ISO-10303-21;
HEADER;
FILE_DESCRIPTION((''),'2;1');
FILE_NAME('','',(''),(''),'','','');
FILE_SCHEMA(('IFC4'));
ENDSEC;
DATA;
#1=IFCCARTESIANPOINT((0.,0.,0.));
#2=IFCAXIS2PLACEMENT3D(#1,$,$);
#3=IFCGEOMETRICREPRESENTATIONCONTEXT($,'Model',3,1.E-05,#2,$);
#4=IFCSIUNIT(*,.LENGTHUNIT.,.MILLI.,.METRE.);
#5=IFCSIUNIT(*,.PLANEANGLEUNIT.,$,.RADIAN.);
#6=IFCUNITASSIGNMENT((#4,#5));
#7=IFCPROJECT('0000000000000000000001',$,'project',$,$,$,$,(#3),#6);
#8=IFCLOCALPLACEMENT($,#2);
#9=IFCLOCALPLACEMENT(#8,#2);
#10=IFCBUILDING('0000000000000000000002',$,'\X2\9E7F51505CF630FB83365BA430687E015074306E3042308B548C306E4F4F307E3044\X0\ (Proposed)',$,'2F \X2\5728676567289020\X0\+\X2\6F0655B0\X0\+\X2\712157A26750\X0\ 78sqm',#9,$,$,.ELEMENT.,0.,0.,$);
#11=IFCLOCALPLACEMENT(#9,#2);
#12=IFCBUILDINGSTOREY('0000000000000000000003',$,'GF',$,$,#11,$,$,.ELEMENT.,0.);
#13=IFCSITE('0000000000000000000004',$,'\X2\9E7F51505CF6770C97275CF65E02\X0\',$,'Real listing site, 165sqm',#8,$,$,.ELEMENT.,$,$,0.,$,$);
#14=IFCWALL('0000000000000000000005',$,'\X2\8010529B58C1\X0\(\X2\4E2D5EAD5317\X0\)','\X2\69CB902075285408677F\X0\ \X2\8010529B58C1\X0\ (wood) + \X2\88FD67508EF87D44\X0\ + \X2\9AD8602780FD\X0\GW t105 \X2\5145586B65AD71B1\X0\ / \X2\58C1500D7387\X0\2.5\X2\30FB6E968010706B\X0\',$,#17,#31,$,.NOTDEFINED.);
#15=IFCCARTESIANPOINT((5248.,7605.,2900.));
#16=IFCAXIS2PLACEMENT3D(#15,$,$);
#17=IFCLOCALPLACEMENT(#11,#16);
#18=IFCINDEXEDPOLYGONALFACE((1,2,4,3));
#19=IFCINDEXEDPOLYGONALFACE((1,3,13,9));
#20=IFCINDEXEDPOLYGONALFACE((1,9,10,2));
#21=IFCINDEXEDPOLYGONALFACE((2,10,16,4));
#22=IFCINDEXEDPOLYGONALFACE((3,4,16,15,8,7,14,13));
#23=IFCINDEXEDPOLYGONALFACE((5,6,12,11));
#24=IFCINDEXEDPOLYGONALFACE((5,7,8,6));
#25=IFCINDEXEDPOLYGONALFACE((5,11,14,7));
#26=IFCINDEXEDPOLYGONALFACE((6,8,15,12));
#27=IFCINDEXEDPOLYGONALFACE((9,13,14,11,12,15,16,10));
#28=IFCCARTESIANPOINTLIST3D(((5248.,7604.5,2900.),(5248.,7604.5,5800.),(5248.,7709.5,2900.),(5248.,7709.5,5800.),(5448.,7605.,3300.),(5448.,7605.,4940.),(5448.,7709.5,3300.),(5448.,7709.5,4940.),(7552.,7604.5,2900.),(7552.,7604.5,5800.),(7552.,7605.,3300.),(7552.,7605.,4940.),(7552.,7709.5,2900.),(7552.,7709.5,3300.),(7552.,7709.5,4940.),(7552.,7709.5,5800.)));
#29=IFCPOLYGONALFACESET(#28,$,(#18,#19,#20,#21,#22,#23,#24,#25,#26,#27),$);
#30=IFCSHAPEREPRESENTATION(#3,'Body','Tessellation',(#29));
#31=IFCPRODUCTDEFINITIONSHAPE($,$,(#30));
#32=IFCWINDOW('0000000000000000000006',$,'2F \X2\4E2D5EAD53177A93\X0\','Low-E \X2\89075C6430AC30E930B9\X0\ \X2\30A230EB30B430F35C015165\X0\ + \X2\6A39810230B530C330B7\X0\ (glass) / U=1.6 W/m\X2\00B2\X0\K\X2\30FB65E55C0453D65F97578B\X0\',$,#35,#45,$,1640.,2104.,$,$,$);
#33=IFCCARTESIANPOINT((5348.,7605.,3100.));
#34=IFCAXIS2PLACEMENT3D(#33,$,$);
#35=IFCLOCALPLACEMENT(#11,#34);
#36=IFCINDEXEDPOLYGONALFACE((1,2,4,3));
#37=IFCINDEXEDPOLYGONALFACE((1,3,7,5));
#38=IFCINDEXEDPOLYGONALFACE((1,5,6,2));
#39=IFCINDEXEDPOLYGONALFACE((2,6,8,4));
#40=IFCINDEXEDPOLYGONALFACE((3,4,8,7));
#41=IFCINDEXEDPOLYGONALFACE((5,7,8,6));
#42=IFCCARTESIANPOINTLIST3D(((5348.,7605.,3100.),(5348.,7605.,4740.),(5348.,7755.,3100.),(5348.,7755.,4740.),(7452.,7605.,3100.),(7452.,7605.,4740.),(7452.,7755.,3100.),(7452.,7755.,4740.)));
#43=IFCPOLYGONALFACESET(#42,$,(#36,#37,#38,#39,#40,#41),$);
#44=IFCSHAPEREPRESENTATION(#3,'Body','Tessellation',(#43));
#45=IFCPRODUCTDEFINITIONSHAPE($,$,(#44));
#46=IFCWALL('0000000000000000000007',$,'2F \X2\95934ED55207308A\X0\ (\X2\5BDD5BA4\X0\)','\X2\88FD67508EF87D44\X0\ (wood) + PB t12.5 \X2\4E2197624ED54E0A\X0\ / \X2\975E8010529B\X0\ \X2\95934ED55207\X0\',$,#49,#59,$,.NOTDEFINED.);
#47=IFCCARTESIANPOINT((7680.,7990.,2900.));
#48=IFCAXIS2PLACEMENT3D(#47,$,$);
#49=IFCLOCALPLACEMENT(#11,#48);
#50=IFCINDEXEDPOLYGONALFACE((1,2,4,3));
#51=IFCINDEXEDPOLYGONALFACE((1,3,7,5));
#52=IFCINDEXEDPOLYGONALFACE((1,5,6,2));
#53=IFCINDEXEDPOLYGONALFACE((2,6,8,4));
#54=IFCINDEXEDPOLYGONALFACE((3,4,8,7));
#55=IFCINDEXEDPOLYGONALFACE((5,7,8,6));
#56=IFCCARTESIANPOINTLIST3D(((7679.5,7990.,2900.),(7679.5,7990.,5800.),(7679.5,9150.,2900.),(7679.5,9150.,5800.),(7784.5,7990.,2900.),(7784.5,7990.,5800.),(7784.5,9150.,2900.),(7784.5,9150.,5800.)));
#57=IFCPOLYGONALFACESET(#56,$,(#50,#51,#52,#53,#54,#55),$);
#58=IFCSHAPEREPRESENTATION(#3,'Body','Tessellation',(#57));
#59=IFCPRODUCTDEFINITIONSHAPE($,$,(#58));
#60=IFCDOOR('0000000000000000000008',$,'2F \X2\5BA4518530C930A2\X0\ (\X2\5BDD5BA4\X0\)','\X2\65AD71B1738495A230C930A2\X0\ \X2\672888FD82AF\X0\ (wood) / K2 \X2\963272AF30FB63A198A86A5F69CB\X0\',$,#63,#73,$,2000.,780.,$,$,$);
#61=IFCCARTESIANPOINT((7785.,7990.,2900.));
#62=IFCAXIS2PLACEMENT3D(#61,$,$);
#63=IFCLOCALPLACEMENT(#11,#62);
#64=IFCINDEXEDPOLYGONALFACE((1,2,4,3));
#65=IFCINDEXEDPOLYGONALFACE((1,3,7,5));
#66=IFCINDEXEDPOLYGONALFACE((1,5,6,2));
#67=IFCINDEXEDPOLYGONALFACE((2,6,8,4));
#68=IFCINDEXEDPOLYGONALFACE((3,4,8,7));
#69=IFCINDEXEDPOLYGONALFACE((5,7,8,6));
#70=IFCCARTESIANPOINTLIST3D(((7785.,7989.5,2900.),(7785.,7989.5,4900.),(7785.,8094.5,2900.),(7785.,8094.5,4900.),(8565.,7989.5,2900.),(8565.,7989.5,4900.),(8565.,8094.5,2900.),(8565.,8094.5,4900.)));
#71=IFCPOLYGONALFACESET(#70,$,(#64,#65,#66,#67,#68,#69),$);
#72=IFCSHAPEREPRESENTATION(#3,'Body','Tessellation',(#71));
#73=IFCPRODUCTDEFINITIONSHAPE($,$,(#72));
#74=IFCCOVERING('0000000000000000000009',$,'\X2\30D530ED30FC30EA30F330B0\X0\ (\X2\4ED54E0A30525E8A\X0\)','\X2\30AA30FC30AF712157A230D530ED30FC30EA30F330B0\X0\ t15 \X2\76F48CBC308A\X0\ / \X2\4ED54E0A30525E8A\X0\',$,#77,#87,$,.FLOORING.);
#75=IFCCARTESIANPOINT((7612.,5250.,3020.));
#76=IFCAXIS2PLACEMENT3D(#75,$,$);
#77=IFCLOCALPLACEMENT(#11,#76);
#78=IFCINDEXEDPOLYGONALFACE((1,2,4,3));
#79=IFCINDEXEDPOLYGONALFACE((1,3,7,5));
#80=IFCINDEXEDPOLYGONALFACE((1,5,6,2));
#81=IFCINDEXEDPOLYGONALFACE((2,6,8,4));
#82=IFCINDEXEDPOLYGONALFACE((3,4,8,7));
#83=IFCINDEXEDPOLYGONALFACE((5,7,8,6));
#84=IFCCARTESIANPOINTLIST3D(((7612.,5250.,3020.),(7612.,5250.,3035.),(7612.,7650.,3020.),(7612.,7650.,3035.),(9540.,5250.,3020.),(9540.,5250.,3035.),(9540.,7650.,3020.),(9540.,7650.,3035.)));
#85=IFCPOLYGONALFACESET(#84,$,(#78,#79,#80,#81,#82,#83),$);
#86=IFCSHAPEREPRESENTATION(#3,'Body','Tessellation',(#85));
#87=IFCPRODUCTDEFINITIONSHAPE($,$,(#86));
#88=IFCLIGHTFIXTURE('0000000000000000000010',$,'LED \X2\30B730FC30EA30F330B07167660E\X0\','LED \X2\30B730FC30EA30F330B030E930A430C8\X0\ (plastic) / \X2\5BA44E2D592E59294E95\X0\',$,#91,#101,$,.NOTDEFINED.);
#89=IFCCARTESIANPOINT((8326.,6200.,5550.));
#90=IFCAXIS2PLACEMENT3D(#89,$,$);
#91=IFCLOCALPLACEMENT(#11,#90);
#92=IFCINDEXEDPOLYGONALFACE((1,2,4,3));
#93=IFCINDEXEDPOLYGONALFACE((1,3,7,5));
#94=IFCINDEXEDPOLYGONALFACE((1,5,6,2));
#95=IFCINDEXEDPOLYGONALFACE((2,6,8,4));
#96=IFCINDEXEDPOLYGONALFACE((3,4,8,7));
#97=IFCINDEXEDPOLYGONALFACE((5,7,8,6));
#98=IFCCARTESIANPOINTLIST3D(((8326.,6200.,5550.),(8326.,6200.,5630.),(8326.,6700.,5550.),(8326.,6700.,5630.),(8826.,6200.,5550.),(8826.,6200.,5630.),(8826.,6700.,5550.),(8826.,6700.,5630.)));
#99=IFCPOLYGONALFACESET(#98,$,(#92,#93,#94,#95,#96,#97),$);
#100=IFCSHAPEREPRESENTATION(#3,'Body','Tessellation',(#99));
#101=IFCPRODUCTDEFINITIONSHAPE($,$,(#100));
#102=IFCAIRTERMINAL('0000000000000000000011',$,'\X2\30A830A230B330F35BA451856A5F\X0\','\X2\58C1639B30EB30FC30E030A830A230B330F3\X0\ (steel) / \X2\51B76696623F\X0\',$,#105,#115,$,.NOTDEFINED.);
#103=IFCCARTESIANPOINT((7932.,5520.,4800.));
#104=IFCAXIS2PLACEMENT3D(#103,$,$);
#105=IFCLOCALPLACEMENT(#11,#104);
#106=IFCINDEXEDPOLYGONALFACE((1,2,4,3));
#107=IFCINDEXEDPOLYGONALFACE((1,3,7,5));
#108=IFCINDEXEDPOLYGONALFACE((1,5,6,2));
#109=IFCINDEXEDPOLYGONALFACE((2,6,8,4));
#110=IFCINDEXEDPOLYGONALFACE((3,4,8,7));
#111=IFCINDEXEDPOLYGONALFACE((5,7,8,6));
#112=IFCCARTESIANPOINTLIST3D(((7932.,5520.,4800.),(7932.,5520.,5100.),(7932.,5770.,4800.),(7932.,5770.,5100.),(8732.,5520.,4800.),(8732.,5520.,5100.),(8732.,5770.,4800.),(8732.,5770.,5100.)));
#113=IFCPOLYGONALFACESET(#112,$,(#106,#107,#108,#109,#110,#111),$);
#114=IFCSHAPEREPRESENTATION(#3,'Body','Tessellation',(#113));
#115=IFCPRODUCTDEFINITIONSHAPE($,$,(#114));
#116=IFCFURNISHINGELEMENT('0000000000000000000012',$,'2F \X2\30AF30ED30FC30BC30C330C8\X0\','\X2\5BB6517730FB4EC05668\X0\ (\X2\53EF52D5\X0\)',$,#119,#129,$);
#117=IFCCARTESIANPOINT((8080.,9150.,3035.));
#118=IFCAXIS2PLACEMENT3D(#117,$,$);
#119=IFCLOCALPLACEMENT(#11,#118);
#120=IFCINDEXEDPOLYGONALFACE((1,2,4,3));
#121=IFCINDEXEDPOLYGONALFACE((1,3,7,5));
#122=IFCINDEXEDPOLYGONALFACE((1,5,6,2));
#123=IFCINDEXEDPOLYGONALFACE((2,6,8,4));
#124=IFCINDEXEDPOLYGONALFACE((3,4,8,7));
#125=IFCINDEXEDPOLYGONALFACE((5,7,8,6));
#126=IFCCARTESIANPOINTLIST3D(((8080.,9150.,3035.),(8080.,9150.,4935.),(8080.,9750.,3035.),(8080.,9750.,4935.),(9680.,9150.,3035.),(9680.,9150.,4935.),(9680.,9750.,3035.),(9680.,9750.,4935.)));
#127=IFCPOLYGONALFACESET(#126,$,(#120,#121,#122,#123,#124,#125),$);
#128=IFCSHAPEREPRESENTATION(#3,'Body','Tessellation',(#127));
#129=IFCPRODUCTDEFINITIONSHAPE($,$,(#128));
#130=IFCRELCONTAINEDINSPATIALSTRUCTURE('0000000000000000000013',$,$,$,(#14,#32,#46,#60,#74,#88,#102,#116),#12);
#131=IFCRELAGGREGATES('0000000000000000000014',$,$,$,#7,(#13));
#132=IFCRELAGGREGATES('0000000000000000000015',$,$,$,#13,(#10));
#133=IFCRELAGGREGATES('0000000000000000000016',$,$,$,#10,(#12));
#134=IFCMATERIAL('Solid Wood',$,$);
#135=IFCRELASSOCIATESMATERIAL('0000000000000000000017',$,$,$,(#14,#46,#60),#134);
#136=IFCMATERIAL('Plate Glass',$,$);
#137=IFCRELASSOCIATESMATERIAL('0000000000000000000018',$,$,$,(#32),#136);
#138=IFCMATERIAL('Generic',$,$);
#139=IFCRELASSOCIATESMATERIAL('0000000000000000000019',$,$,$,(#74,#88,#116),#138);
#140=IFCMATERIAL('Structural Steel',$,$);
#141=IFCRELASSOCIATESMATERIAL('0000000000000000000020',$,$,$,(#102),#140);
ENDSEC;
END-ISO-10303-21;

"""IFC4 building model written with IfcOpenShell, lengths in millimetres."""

from ifc_helpers import new_model, si_unit, frame, frame_2d, origin, place, context, project, spatial, rectangle, extrude, material, element, fill, save


model = new_model("IFC4")

# Units and contexts
model_context = context("Model", 3, precision=1e-05, world=origin())
ifc_project = project(units=[si_unit("LENGTHUNIT", "METRE", prefix="MILLI"), si_unit("PLANEANGLEUNIT", "RADIAN")], contexts=[model_context])

# Site, building, storey
site_placement = place(None, origin())
site = spatial("IfcSite", under=ifc_project, at=site_placement, Name="鹿児島県霧島市", ObjectType="Real listing site, 165sqm", CompositionType="ELEMENT", RefElevation=0.0)
building_placement = place(site_placement, origin())
building = spatial("IfcBuilding", under=site, at=building_placement, Name="鹿児島・茶室と縁側のある和の住まい (Proposed)", ObjectType="2F 在来木造+漆喰+無垢材 78sqm", CompositionType="ELEMENT", ElevationOfRefHeight=0.0, ElevationOfTerrain=0.0)
storey_placement = place(building_placement, origin())
storey = spatial("IfcBuildingStorey", under=building, at=storey_placement, Name="GF", CompositionType="ELEMENT", Elevation=0.0)

# Shared definitions
ifc_material_1 = material(Name="Solid Wood")

# Wall, opening, window
wall_1_placement = place(storey_placement, frame((5248.0, 7605.0, 2900.0)))
wall_1 = element("IfcWall", 1, at=wall_1_placement, inside=storey, material=ifc_material_1, Name="耐力壁(中庭北)", Description="構造用合板 耐力壁 (wood) + 製材軸組 + 高性能GW t105 充填断熱 / 壁倍率2.5・準耐火", PredefinedType="NOTDEFINED", context=model_context, shape_type="SweptSolid", body=[
    extrude(rectangle(XDim=2304.0, YDim=105.0, at=frame_2d((1152.0, 52.0))), frame((5248.0, 7605.0, 2900.0)), (0.0, 0.0, 1.0), 2900.0),
])
opening_placement = place(storey_placement, frame((5348.0, 7605.0, 3100.0)))
opening = element("IfcOpeningElement", 2, at=opening_placement, cuts=wall_1, PredefinedType="NOTDEFINED", context=model_context, shape_type="SweptSolid", body=[
    extrude(rectangle(XDim=2104.0, YDim=150.0, at=frame_2d((1052.0, 75.0))), frame((5348.0, 7605.0, 3100.0)), (0.0, 0.0, 1.0), 1640.0),
])
ifc_material_2 = material(Name="Plate Glass")
window_placement = place(storey_placement, frame((5348.0, 7605.0, 3100.0)))
window = element("IfcWindow", 3, at=window_placement, inside=storey, material=ifc_material_2, Name="2F 中庭北窓", Description="Low-E 複層ガラス アルゴン封入 + 樹脂サッシ (glass) / U=1.6 W/m²K・日射取得型", OverallHeight=1640.0, OverallWidth=2104.0, context=model_context, shape_type="SweptSolid", body=[
    extrude(rectangle(XDim=2104.0, YDim=150.0, at=frame_2d((1052.0, 75.0))), frame((5348.0, 7605.0, 3100.0)), (0.0, 0.0, 1.0), 1640.0),
])
fill(opening, window)

# Wall
wall_2_placement = place(storey_placement, frame((7680.0, 7990.0, 2900.0)))
element("IfcWall", 4, at=wall_2_placement, inside=storey, material=ifc_material_1, Name="2F 間仕切り (寝室)", Description="製材軸組 (wood) + PB t12.5 両面仕上 / 非耐力 間仕切", PredefinedType="NOTDEFINED", context=model_context, shape_type="SweptSolid", body=[
    extrude(rectangle(XDim=105.0, YDim=1160.0, at=frame_2d((52.0, 580.0))), frame((7680.0, 7990.0, 2900.0)), (0.0, 0.0, 1.0), 2900.0),
])

# Door
door_placement = place(storey_placement, frame((7785.0, 7990.0, 2900.0)))
element("IfcDoor", 5, at=door_placement, inside=storey, material=ifc_material_1, Name="2F 室内ドア (寝室)", Description="断熱玄関ドア 木製芯 (wood) / K2 防犯・採風機構", OverallHeight=2000.0, OverallWidth=780.0, context=model_context, shape_type="SweptSolid", body=[
    extrude(rectangle(XDim=780.0, YDim=105.0, at=frame_2d((390.0, 52.0))), frame((7785.0, 7990.0, 2900.0)), (0.0, 0.0, 1.0), 2000.0),
])

# Covering
ifc_material_3 = material(Name="Generic")
covering_placement = place(storey_placement, frame((7612.0, 5250.0, 3020.0)))
element("IfcCovering", 6, at=covering_placement, inside=storey, material=ifc_material_3, Name="フローリング (仕上げ床)", Description="オーク無垢フローリング t15 直貼り / 仕上げ床", PredefinedType="FLOORING", context=model_context, shape_type="SweptSolid", body=[
    extrude(rectangle(XDim=1928.0, YDim=2400.0, at=frame_2d((964.0, 1200.0))), frame((7612.0, 5250.0, 3020.0)), (0.0, 0.0, 1.0), 15.0),
])

# Light fixture
light_fixture_placement = place(storey_placement, frame((8326.0, 6200.0, 5550.0)))
element("IfcLightFixture", 7, at=light_fixture_placement, inside=storey, material=ifc_material_3, Name="LED シーリング照明", Description="LED シーリングライト (plastic) / 室中央天井", PredefinedType="NOTDEFINED", context=model_context, shape_type="SweptSolid", body=[
    extrude(rectangle(XDim=500.0, YDim=500.0, at=frame_2d((250.0, 250.0))), frame((8326.0, 6200.0, 5550.0)), (0.0, 0.0, 1.0), 80.0),
])

# Air terminal
ifc_material_4 = material(Name="Structural Steel")
air_terminal_placement = place(storey_placement, frame((7932.0, 5520.0, 4800.0)))
element("IfcAirTerminal", 8, at=air_terminal_placement, inside=storey, material=ifc_material_4, Name="エアコン室内機", Description="壁掛ルームエアコン (steel) / 冷暖房", PredefinedType="NOTDEFINED", context=model_context, shape_type="SweptSolid", body=[
    extrude(rectangle(XDim=800.0, YDim=250.0, at=frame_2d((400.0, 125.0))), frame((7932.0, 5520.0, 4800.0)), (0.0, 0.0, 1.0), 300.0),
])

# Furnishing element
furnishing_placement = place(storey_placement, frame((8080.0, 9150.0, 3035.0)))
element("IfcFurnishingElement", 9, at=furnishing_placement, inside=storey, material=ifc_material_3, Name="2F クローゼット", Description="家具・什器 (可動)", context=model_context, shape_type="SweptSolid", body=[
    extrude(rectangle(XDim=1600.0, YDim=600.0, at=frame_2d((800.0, 300.0))), frame((8080.0, 9150.0, 3035.0)), (0.0, 0.0, 1.0), 1900.0),
])

save(model, "model.ifc")
